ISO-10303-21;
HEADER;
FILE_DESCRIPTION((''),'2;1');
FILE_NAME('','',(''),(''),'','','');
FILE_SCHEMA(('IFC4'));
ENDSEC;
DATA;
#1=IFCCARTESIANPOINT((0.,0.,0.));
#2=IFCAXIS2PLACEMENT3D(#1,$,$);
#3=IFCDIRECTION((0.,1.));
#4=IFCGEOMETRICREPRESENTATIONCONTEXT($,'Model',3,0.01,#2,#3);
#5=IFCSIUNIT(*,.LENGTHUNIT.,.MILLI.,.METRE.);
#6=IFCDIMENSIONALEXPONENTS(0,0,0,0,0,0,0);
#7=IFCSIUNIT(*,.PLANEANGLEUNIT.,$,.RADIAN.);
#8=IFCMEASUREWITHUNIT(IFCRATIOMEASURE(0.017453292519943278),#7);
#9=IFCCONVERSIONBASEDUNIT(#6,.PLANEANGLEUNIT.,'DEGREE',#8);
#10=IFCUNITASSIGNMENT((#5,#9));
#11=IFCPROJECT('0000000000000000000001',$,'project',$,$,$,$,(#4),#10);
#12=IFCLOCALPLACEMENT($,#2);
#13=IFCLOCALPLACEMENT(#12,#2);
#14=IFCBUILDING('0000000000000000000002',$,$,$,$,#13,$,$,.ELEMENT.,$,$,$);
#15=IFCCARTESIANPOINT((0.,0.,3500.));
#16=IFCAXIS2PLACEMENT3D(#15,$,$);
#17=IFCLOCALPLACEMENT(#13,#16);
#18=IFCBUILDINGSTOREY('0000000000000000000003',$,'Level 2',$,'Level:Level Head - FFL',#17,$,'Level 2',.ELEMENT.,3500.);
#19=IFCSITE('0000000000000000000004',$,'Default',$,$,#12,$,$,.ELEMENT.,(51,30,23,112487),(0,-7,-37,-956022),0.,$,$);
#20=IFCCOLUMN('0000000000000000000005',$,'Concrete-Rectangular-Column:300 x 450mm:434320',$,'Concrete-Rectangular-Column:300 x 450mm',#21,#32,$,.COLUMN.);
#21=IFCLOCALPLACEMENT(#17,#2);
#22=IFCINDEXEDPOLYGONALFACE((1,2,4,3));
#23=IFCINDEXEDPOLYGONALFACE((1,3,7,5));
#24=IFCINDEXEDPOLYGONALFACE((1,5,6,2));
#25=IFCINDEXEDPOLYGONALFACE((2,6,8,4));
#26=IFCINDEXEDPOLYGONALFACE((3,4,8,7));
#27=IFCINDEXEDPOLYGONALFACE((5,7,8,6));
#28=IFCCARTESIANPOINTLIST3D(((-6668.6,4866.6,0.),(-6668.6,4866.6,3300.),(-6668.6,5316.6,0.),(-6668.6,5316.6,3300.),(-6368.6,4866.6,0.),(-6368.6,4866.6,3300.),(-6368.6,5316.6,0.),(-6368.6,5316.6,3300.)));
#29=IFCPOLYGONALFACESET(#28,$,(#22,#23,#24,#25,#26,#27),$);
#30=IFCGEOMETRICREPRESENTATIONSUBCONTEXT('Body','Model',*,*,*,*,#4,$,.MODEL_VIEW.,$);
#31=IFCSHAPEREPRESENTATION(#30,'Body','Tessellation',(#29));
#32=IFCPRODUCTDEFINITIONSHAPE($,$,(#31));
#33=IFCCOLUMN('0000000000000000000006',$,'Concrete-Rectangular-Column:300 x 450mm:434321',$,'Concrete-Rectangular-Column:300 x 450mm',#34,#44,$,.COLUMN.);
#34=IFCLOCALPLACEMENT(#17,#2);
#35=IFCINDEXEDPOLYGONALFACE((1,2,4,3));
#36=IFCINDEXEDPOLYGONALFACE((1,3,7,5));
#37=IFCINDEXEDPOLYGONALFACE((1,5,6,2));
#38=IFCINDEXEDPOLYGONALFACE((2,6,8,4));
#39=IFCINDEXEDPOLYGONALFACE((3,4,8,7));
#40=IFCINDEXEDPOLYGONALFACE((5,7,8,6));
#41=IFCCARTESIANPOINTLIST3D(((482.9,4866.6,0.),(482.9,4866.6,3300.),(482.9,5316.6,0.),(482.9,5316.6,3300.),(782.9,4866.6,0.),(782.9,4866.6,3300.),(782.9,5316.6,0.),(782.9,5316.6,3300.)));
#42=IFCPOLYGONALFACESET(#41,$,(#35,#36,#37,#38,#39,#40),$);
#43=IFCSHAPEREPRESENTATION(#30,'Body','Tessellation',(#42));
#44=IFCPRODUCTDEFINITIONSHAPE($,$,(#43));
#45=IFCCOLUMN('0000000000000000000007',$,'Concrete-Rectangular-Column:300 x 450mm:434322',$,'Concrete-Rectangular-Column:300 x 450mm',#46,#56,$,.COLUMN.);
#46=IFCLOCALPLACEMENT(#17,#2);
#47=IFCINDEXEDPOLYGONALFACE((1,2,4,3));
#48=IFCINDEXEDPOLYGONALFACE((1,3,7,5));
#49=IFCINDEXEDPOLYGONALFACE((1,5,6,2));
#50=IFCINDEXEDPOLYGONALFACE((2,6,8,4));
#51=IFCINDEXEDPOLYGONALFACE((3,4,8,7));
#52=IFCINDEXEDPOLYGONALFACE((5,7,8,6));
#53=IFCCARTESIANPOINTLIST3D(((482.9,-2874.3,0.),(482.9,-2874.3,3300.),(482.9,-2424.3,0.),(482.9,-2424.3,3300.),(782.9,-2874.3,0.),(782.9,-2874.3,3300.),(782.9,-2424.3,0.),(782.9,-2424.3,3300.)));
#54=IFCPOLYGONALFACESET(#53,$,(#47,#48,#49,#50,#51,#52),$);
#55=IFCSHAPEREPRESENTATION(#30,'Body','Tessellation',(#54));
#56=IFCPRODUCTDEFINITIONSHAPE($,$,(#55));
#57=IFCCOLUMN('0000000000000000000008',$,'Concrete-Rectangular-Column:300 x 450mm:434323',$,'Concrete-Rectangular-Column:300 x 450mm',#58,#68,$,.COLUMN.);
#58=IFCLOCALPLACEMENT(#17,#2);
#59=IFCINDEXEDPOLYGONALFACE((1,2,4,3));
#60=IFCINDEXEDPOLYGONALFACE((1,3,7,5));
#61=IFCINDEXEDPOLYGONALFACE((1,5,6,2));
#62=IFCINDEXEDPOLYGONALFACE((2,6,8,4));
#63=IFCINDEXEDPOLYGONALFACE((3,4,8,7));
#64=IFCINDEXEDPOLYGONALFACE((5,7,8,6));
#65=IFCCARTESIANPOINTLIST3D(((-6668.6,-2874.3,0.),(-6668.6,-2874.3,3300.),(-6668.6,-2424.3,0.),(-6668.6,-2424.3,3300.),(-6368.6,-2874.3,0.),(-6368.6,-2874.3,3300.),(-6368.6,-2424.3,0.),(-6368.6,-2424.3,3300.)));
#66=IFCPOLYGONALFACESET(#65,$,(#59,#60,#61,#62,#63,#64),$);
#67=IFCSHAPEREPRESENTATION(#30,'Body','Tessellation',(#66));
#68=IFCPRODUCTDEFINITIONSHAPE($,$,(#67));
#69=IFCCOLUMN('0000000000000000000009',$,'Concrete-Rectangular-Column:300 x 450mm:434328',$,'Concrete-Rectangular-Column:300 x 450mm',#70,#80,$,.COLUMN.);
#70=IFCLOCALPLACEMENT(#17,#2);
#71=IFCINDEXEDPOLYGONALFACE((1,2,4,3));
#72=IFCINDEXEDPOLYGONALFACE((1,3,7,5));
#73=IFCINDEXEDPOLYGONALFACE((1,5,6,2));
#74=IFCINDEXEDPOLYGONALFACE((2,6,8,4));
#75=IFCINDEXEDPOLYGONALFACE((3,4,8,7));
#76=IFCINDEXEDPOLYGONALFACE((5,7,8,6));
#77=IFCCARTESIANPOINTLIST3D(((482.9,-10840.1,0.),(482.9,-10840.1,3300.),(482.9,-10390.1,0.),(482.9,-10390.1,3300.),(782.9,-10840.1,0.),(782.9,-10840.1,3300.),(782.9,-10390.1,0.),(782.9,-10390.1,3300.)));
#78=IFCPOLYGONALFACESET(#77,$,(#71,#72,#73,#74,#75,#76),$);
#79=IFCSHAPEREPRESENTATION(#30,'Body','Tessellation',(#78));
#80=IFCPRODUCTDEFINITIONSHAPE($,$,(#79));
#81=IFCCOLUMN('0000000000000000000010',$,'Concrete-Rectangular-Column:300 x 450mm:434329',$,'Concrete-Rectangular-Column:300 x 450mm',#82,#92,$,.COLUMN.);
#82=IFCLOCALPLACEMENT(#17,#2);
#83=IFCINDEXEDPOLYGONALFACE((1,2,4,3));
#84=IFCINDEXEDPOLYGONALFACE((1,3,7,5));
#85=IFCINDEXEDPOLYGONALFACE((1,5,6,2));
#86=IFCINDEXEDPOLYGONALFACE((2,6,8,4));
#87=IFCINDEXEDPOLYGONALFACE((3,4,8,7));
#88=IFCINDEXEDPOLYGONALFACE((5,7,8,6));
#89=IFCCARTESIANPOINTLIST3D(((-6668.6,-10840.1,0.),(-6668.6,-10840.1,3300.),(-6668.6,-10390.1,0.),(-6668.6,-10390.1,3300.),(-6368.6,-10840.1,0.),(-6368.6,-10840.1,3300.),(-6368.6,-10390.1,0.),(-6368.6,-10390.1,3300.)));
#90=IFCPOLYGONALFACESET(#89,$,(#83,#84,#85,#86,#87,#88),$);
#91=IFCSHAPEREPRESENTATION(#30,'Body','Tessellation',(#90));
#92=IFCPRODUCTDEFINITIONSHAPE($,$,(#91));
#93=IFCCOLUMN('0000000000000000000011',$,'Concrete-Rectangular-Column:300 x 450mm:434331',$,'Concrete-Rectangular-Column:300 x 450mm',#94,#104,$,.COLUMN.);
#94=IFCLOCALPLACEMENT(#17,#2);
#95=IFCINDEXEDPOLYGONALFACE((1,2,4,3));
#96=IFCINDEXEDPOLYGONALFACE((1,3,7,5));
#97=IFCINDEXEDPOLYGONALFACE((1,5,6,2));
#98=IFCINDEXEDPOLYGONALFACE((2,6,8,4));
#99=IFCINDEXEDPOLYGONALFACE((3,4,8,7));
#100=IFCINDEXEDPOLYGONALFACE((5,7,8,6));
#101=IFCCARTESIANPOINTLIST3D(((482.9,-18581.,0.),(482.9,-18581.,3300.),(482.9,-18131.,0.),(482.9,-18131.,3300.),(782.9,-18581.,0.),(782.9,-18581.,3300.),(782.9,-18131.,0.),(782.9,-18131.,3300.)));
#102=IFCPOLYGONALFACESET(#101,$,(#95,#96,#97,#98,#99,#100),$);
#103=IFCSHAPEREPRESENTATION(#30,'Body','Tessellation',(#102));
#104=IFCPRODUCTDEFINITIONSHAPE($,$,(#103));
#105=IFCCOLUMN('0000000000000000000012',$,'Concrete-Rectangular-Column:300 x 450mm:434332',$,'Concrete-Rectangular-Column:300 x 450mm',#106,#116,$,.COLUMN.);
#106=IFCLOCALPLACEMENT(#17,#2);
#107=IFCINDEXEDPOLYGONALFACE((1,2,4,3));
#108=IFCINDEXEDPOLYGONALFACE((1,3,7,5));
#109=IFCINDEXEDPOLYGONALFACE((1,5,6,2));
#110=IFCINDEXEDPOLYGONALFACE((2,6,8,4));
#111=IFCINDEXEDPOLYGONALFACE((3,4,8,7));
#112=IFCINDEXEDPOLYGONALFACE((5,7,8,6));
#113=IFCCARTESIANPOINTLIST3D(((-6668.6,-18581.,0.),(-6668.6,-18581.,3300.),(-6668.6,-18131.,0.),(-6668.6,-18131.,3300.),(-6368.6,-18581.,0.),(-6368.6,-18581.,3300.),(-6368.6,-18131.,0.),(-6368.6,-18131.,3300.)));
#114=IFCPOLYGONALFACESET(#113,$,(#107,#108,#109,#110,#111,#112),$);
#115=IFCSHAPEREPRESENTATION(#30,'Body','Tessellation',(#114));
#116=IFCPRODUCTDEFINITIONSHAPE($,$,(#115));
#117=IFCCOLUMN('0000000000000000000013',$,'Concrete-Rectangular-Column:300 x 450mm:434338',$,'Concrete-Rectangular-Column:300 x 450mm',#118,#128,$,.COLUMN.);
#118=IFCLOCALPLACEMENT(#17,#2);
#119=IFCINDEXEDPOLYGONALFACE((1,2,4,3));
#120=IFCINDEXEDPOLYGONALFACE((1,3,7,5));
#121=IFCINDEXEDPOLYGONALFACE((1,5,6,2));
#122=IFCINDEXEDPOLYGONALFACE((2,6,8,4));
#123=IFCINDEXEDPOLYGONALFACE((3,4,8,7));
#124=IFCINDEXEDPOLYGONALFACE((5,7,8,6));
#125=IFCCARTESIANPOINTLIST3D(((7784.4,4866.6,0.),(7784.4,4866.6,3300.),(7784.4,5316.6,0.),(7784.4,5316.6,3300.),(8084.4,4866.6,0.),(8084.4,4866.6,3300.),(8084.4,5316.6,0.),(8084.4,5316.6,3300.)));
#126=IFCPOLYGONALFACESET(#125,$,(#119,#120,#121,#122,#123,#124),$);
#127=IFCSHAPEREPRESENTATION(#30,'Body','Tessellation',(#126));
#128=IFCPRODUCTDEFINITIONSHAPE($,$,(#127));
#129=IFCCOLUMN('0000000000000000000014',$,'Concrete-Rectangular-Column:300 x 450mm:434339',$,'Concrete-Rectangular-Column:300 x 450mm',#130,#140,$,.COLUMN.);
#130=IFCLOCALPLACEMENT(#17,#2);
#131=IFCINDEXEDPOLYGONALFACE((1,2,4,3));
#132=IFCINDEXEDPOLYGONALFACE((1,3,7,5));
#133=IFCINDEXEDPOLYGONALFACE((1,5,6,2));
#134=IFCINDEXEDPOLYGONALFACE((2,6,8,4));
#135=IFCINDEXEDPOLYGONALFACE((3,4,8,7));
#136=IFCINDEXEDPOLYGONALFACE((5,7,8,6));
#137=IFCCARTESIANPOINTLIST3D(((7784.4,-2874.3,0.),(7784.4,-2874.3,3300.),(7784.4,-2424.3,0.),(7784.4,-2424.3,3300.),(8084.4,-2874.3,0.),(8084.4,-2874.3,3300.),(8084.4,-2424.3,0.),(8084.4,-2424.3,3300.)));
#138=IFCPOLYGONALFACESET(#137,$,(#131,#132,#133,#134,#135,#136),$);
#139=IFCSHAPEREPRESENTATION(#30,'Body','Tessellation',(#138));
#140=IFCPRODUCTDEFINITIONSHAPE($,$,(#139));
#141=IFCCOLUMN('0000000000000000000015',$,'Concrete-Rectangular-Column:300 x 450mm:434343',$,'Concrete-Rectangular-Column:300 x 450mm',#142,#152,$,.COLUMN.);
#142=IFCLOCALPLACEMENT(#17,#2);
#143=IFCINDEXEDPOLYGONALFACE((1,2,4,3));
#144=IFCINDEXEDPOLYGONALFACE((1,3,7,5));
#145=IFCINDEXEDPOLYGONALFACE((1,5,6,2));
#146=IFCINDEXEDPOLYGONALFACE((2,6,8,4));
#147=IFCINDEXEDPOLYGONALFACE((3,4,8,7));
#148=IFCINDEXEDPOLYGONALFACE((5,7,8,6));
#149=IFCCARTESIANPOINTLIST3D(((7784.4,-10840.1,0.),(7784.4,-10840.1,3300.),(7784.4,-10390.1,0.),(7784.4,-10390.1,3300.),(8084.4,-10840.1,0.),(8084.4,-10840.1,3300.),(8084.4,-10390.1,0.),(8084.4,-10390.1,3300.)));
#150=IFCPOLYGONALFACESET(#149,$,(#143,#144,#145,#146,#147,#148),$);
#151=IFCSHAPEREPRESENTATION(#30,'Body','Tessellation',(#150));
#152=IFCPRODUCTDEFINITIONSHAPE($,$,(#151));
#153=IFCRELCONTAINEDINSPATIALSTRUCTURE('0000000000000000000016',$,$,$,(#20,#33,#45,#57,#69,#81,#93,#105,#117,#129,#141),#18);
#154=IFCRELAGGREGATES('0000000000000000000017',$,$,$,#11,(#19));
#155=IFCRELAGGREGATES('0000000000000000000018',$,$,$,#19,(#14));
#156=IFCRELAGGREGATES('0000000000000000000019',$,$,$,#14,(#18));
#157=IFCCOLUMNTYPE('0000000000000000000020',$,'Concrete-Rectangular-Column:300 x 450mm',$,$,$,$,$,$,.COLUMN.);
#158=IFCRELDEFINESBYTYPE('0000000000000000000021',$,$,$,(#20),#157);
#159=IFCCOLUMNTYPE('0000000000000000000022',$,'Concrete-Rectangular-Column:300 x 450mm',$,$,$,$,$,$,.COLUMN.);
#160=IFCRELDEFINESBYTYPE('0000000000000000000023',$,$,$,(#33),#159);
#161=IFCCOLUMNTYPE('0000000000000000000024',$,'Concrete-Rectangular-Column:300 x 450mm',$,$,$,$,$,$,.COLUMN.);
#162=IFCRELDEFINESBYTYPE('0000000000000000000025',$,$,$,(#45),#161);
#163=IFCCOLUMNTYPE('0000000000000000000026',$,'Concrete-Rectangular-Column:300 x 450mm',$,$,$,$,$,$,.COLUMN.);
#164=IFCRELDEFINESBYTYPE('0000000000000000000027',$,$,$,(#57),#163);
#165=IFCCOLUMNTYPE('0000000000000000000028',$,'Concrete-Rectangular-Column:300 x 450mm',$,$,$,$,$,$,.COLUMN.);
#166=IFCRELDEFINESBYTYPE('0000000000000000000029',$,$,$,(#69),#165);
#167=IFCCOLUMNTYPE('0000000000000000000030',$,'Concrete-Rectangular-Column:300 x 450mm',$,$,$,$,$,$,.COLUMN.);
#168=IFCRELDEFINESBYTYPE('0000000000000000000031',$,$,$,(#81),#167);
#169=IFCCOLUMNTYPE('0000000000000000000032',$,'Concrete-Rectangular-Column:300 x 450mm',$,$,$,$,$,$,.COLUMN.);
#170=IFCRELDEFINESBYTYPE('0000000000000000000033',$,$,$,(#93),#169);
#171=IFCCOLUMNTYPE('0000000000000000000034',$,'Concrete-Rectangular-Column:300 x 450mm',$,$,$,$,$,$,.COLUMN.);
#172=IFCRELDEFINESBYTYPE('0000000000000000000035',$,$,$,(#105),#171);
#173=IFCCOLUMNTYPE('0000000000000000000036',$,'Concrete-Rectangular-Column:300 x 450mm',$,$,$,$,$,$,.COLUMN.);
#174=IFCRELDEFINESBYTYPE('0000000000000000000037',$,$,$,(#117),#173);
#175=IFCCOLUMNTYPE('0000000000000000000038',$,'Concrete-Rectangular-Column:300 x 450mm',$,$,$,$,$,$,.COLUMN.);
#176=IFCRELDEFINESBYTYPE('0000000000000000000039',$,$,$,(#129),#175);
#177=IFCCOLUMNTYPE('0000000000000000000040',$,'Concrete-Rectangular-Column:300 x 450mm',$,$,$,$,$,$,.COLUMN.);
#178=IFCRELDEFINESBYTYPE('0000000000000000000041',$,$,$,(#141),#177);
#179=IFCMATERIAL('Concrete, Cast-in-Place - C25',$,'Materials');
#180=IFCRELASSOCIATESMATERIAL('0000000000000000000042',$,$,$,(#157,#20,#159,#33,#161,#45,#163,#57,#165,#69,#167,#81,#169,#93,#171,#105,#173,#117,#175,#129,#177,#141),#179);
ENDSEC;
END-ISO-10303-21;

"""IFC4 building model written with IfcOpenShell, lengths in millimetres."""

from ifc_helpers import new_model, entity, si_unit, converted_unit, direction, frame, origin, place, context, subcontext, project, spatial, indexed_curve, outline, extrude, source, transform, mapped, material, type_object, type_shapes, element, save


model = new_model("IFC4")

# Units and contexts
model_context = context("Model", 3, precision=0.01, world=origin(), true_north=direction((0.0, 1.0)))
body_context = subcontext(model_context, "Body", "Model", "MODEL_VIEW")
ifc_project = project(units=[si_unit("LENGTHUNIT", "METRE", prefix="MILLI"), converted_unit("PLANEANGLEUNIT", "DEGREE", entity("IfcRatioMeasure", 0.017453292519943278), si_unit("PLANEANGLEUNIT", "RADIAN"), dimensions=[0, 0, 0, 0, 0, 0, 0])], contexts=[model_context])

# Site, building, storey
site_placement = place(None, origin())
site = spatial("IfcSite", under=ifc_project, at=site_placement, Name="Default", CompositionType="ELEMENT", RefLatitude=(51, 30, 23, 112487), RefLongitude=(0, -7, -37, -956022), RefElevation=0.0)
building_placement = place(site_placement, origin())
building = spatial("IfcBuilding", under=site, at=building_placement, CompositionType="ELEMENT")
storey_placement = place(building_placement, frame((0.0, 0.0, 3500.0)))
storey = spatial("IfcBuildingStorey", under=building, at=storey_placement, Name="Level 2", ObjectType="Level:Level Head - FFL", LongName="Level 2", CompositionType="ELEMENT", Elevation=3500.0)

# Columns
ifc_material = material(Name="Concrete, Cast-in-Place - C25", Category="Materials")
column_type_1 = type_object("IfcColumnType", Name="Concrete-Rectangular-Column:300 x 450mm", PredefinedType="COLUMN", material=ifc_material)
shared_shape_1 = source(origin(), body_context, "Body", "SweptSolid", [
    extrude(outline(indexed_curve([(-225.0, -150.0), (225.0, -150.0), (225.0, 150.0), (-225.0, 150.0), (-225.0, -150.0)], self_intersect=False)), frame((-6518.6, 5091.6, 3500.0), z_axis=(0.0, 0.0, 1.0), x_axis=(0.0, -1.0, 0.0)), (0.0, 0.0, 1.0), 3300.0),
])
type_shapes(column_type_1, [shared_shape_1])
column_1_placement = place(storey_placement, frame((0.0, 0.0, -3500.0)))
element("IfcColumn", 1, at=column_1_placement, inside=storey, type_object=column_type_1, material=ifc_material, Name="Concrete-Rectangular-Column:300 x 450mm:434320", ObjectType="Concrete-Rectangular-Column:300 x 450mm", PredefinedType="COLUMN", context=body_context, shape_type="MappedRepresentation", body=[
    mapped(shared_shape_1, transform((0.0, 0.0, 0.0), scale=1.0)),
])
column_type_2 = type_object("IfcColumnType", Name="Concrete-Rectangular-Column:300 x 450mm", PredefinedType="COLUMN", material=ifc_material)
shared_shape_2 = source(origin(), body_context, "Body", "SweptSolid", [
    extrude(outline(indexed_curve([(-225.0, -150.0), (225.0, -150.0), (225.0, 150.0), (-225.0, 150.0), (-225.0, -150.0)], self_intersect=False)), frame((632.9, 5091.6, 3500.0), z_axis=(0.0, 0.0, 1.0), x_axis=(0.0, -1.0, 0.0)), (0.0, 0.0, 1.0), 3300.0),
])
type_shapes(column_type_2, [shared_shape_2])
column_2_placement = place(storey_placement, frame((0.0, 0.0, -3500.0)))
element("IfcColumn", 2, at=column_2_placement, inside=storey, type_object=column_type_2, material=ifc_material, Name="Concrete-Rectangular-Column:300 x 450mm:434321", ObjectType="Concrete-Rectangular-Column:300 x 450mm", PredefinedType="COLUMN", context=body_context, shape_type="MappedRepresentation", body=[
    mapped(shared_shape_2, transform((0.0, 0.0, 0.0), scale=1.0)),
])
column_type_3 = type_object("IfcColumnType", Name="Concrete-Rectangular-Column:300 x 450mm", PredefinedType="COLUMN", material=ifc_material)
shared_shape_3 = source(origin(), body_context, "Body", "SweptSolid", [
    extrude(outline(indexed_curve([(-225.0, -150.0), (225.0, -150.0), (225.0, 150.0), (-225.0, 150.0), (-225.0, -150.0)], self_intersect=False)), frame((632.9, -2649.3, 3500.0), z_axis=(0.0, 0.0, 1.0), x_axis=(0.0, -1.0, 0.0)), (0.0, 0.0, 1.0), 3300.0),
])
type_shapes(column_type_3, [shared_shape_3])
column_3_placement = place(storey_placement, frame((0.0, 0.0, -3500.0)))
element("IfcColumn", 3, at=column_3_placement, inside=storey, type_object=column_type_3, material=ifc_material, Name="Concrete-Rectangular-Column:300 x 450mm:434322", ObjectType="Concrete-Rectangular-Column:300 x 450mm", PredefinedType="COLUMN", context=body_context, shape_type="MappedRepresentation", body=[
    mapped(shared_shape_3, transform((0.0, 0.0, 0.0), scale=1.0)),
])
column_type_4 = type_object("IfcColumnType", Name="Concrete-Rectangular-Column:300 x 450mm", PredefinedType="COLUMN", material=ifc_material)
shared_shape_4 = source(origin(), body_context, "Body", "SweptSolid", [
    extrude(outline(indexed_curve([(-225.0, -150.0), (225.0, -150.0), (225.0, 150.0), (-225.0, 150.0), (-225.0, -150.0)], self_intersect=False)), frame((-6518.6, -2649.3, 3500.0), z_axis=(0.0, 0.0, 1.0), x_axis=(0.0, -1.0, 0.0)), (0.0, 0.0, 1.0), 3300.0),
])
type_shapes(column_type_4, [shared_shape_4])
column_4_placement = place(storey_placement, frame((0.0, 0.0, -3500.0)))
element("IfcColumn", 4, at=column_4_placement, inside=storey, type_object=column_type_4, material=ifc_material, Name="Concrete-Rectangular-Column:300 x 450mm:434323", ObjectType="Concrete-Rectangular-Column:300 x 450mm", PredefinedType="COLUMN", context=body_context, shape_type="MappedRepresentation", body=[
    mapped(shared_shape_4, transform((0.0, 0.0, 0.0), scale=1.0)),
])
column_type_5 = type_object("IfcColumnType", Name="Concrete-Rectangular-Column:300 x 450mm", PredefinedType="COLUMN", material=ifc_material)
shared_shape_5 = source(origin(), body_context, "Body", "SweptSolid", [
    extrude(outline(indexed_curve([(-225.0, -150.0), (225.0, -150.0), (225.0, 150.0), (-225.0, 150.0), (-225.0, -150.0)], self_intersect=False)), frame((632.9, -10615.1, 3500.0), z_axis=(0.0, 0.0, 1.0), x_axis=(0.0, -1.0, 0.0)), (0.0, 0.0, 1.0), 3300.0),
])
type_shapes(column_type_5, [shared_shape_5])
column_5_placement = place(storey_placement, frame((0.0, 0.0, -3500.0)))
element("IfcColumn", 5, at=column_5_placement, inside=storey, type_object=column_type_5, material=ifc_material, Name="Concrete-Rectangular-Column:300 x 450mm:434328", ObjectType="Concrete-Rectangular-Column:300 x 450mm", PredefinedType="COLUMN", context=body_context, shape_type="MappedRepresentation", body=[
    mapped(shared_shape_5, transform((0.0, 0.0, 0.0), scale=1.0)),
])
column_type_6 = type_object("IfcColumnType", Name="Concrete-Rectangular-Column:300 x 450mm", PredefinedType="COLUMN", material=ifc_material)
shared_shape_6 = source(origin(), body_context, "Body", "SweptSolid", [
    extrude(outline(indexed_curve([(-225.0, -150.0), (225.0, -150.0), (225.0, 150.0), (-225.0, 150.0), (-225.0, -150.0)], self_intersect=False)), frame((-6518.6, -10615.1, 3500.0), z_axis=(0.0, 0.0, 1.0), x_axis=(0.0, -1.0, 0.0)), (0.0, 0.0, 1.0), 3300.0),
])
type_shapes(column_type_6, [shared_shape_6])
column_6_placement = place(storey_placement, frame((0.0, 0.0, -3500.0)))
element("IfcColumn", 6, at=column_6_placement, inside=storey, type_object=column_type_6, material=ifc_material, Name="Concrete-Rectangular-Column:300 x 450mm:434329", ObjectType="Concrete-Rectangular-Column:300 x 450mm", PredefinedType="COLUMN", context=body_context, shape_type="MappedRepresentation", body=[
    mapped(shared_shape_6, transform((0.0, 0.0, 0.0), scale=1.0)),
])
column_type_7 = type_object("IfcColumnType", Name="Concrete-Rectangular-Column:300 x 450mm", PredefinedType="COLUMN", material=ifc_material)
shared_shape_7 = source(origin(), body_context, "Body", "SweptSolid", [
    extrude(outline(indexed_curve([(-225.0, -150.0), (225.0, -150.0), (225.0, 150.0), (-225.0, 150.0), (-225.0, -150.0)], self_intersect=False)), frame((632.9, -18356.0, 3500.0), z_axis=(0.0, 0.0, 1.0), x_axis=(0.0, -1.0, 0.0)), (0.0, 0.0, 1.0), 3300.0),
])
type_shapes(column_type_7, [shared_shape_7])
column_7_placement = place(storey_placement, frame((0.0, 0.0, -3500.0)))
element("IfcColumn", 7, at=column_7_placement, inside=storey, type_object=column_type_7, material=ifc_material, Name="Concrete-Rectangular-Column:300 x 450mm:434331", ObjectType="Concrete-Rectangular-Column:300 x 450mm", PredefinedType="COLUMN", context=body_context, shape_type="MappedRepresentation", body=[
    mapped(shared_shape_7, transform((0.0, 0.0, 0.0), scale=1.0)),
])
column_type_8 = type_object("IfcColumnType", Name="Concrete-Rectangular-Column:300 x 450mm", PredefinedType="COLUMN", material=ifc_material)
shared_shape_8 = source(origin(), body_context, "Body", "SweptSolid", [
    extrude(outline(indexed_curve([(-225.0, -150.0), (225.0, -150.0), (225.0, 150.0), (-225.0, 150.0), (-225.0, -150.0)], self_intersect=False)), frame((-6518.6, -18356.0, 3500.0), z_axis=(0.0, 0.0, 1.0), x_axis=(0.0, -1.0, 0.0)), (0.0, 0.0, 1.0), 3300.0),
])
type_shapes(column_type_8, [shared_shape_8])
column_8_placement = place(storey_placement, frame((0.0, 0.0, -3500.0)))
element("IfcColumn", 8, at=column_8_placement, inside=storey, type_object=column_type_8, material=ifc_material, Name="Concrete-Rectangular-Column:300 x 450mm:434332", ObjectType="Concrete-Rectangular-Column:300 x 450mm", PredefinedType="COLUMN", context=body_context, shape_type="MappedRepresentation", body=[
    mapped(shared_shape_8, transform((0.0, 0.0, 0.0), scale=1.0)),
])
column_type_9 = type_object("IfcColumnType", Name="Concrete-Rectangular-Column:300 x 450mm", PredefinedType="COLUMN", material=ifc_material)
shared_shape_9 = source(origin(), body_context, "Body", "SweptSolid", [
    extrude(outline(indexed_curve([(-225.0, -150.0), (225.0, -150.0), (225.0, 150.0), (-225.0, 150.0), (-225.0, -150.0)], self_intersect=False)), frame((7934.4, 5091.6, 3500.0), z_axis=(0.0, 0.0, 1.0), x_axis=(0.0, -1.0, 0.0)), (0.0, 0.0, 1.0), 3300.0),
])
type_shapes(column_type_9, [shared_shape_9])
column_9_placement = place(storey_placement, frame((0.0, 0.0, -3500.0)))
element("IfcColumn", 9, at=column_9_placement, inside=storey, type_object=column_type_9, material=ifc_material, Name="Concrete-Rectangular-Column:300 x 450mm:434338", ObjectType="Concrete-Rectangular-Column:300 x 450mm", PredefinedType="COLUMN", context=body_context, shape_type="MappedRepresentation", body=[
    mapped(shared_shape_9, transform((0.0, 0.0, 0.0), scale=1.0)),
])
column_type_10 = type_object("IfcColumnType", Name="Concrete-Rectangular-Column:300 x 450mm", PredefinedType="COLUMN", material=ifc_material)
shared_shape_10 = source(origin(), body_context, "Body", "SweptSolid", [
    extrude(outline(indexed_curve([(-225.0, -150.0), (225.0, -150.0), (225.0, 150.0), (-225.0, 150.0), (-225.0, -150.0)], self_intersect=False)), frame((7934.4, -2649.3, 3500.0), z_axis=(0.0, 0.0, 1.0), x_axis=(0.0, -1.0, 0.0)), (0.0, 0.0, 1.0), 3300.0),
])
type_shapes(column_type_10, [shared_shape_10])
column_10_placement = place(storey_placement, frame((0.0, 0.0, -3500.0)))
element("IfcColumn", 10, at=column_10_placement, inside=storey, type_object=column_type_10, material=ifc_material, Name="Concrete-Rectangular-Column:300 x 450mm:434339", ObjectType="Concrete-Rectangular-Column:300 x 450mm", PredefinedType="COLUMN", context=body_context, shape_type="MappedRepresentation", body=[
    mapped(shared_shape_10, transform((0.0, 0.0, 0.0), scale=1.0)),
])
column_type_11 = type_object("IfcColumnType", Name="Concrete-Rectangular-Column:300 x 450mm", PredefinedType="COLUMN", material=ifc_material)
shared_shape_11 = source(origin(), body_context, "Body", "SweptSolid", [
    extrude(outline(indexed_curve([(-225.0, -150.0), (225.0, -150.0), (225.0, 150.0), (-225.0, 150.0), (-225.0, -150.0)], self_intersect=False)), frame((7934.4, -10615.1, 3500.0), z_axis=(0.0, 0.0, 1.0), x_axis=(0.0, -1.0, 0.0)), (0.0, 0.0, 1.0), 3300.0),
])
type_shapes(column_type_11, [shared_shape_11])
column_11_placement = place(storey_placement, frame((0.0, 0.0, -3500.0)))
element("IfcColumn", 11, at=column_11_placement, inside=storey, type_object=column_type_11, material=ifc_material, Name="Concrete-Rectangular-Column:300 x 450mm:434343", ObjectType="Concrete-Rectangular-Column:300 x 450mm", PredefinedType="COLUMN", context=body_context, shape_type="MappedRepresentation", body=[
    mapped(shared_shape_11, transform((0.0, 0.0, 0.0), scale=1.0)),
])

save(model, "model.ifc")
